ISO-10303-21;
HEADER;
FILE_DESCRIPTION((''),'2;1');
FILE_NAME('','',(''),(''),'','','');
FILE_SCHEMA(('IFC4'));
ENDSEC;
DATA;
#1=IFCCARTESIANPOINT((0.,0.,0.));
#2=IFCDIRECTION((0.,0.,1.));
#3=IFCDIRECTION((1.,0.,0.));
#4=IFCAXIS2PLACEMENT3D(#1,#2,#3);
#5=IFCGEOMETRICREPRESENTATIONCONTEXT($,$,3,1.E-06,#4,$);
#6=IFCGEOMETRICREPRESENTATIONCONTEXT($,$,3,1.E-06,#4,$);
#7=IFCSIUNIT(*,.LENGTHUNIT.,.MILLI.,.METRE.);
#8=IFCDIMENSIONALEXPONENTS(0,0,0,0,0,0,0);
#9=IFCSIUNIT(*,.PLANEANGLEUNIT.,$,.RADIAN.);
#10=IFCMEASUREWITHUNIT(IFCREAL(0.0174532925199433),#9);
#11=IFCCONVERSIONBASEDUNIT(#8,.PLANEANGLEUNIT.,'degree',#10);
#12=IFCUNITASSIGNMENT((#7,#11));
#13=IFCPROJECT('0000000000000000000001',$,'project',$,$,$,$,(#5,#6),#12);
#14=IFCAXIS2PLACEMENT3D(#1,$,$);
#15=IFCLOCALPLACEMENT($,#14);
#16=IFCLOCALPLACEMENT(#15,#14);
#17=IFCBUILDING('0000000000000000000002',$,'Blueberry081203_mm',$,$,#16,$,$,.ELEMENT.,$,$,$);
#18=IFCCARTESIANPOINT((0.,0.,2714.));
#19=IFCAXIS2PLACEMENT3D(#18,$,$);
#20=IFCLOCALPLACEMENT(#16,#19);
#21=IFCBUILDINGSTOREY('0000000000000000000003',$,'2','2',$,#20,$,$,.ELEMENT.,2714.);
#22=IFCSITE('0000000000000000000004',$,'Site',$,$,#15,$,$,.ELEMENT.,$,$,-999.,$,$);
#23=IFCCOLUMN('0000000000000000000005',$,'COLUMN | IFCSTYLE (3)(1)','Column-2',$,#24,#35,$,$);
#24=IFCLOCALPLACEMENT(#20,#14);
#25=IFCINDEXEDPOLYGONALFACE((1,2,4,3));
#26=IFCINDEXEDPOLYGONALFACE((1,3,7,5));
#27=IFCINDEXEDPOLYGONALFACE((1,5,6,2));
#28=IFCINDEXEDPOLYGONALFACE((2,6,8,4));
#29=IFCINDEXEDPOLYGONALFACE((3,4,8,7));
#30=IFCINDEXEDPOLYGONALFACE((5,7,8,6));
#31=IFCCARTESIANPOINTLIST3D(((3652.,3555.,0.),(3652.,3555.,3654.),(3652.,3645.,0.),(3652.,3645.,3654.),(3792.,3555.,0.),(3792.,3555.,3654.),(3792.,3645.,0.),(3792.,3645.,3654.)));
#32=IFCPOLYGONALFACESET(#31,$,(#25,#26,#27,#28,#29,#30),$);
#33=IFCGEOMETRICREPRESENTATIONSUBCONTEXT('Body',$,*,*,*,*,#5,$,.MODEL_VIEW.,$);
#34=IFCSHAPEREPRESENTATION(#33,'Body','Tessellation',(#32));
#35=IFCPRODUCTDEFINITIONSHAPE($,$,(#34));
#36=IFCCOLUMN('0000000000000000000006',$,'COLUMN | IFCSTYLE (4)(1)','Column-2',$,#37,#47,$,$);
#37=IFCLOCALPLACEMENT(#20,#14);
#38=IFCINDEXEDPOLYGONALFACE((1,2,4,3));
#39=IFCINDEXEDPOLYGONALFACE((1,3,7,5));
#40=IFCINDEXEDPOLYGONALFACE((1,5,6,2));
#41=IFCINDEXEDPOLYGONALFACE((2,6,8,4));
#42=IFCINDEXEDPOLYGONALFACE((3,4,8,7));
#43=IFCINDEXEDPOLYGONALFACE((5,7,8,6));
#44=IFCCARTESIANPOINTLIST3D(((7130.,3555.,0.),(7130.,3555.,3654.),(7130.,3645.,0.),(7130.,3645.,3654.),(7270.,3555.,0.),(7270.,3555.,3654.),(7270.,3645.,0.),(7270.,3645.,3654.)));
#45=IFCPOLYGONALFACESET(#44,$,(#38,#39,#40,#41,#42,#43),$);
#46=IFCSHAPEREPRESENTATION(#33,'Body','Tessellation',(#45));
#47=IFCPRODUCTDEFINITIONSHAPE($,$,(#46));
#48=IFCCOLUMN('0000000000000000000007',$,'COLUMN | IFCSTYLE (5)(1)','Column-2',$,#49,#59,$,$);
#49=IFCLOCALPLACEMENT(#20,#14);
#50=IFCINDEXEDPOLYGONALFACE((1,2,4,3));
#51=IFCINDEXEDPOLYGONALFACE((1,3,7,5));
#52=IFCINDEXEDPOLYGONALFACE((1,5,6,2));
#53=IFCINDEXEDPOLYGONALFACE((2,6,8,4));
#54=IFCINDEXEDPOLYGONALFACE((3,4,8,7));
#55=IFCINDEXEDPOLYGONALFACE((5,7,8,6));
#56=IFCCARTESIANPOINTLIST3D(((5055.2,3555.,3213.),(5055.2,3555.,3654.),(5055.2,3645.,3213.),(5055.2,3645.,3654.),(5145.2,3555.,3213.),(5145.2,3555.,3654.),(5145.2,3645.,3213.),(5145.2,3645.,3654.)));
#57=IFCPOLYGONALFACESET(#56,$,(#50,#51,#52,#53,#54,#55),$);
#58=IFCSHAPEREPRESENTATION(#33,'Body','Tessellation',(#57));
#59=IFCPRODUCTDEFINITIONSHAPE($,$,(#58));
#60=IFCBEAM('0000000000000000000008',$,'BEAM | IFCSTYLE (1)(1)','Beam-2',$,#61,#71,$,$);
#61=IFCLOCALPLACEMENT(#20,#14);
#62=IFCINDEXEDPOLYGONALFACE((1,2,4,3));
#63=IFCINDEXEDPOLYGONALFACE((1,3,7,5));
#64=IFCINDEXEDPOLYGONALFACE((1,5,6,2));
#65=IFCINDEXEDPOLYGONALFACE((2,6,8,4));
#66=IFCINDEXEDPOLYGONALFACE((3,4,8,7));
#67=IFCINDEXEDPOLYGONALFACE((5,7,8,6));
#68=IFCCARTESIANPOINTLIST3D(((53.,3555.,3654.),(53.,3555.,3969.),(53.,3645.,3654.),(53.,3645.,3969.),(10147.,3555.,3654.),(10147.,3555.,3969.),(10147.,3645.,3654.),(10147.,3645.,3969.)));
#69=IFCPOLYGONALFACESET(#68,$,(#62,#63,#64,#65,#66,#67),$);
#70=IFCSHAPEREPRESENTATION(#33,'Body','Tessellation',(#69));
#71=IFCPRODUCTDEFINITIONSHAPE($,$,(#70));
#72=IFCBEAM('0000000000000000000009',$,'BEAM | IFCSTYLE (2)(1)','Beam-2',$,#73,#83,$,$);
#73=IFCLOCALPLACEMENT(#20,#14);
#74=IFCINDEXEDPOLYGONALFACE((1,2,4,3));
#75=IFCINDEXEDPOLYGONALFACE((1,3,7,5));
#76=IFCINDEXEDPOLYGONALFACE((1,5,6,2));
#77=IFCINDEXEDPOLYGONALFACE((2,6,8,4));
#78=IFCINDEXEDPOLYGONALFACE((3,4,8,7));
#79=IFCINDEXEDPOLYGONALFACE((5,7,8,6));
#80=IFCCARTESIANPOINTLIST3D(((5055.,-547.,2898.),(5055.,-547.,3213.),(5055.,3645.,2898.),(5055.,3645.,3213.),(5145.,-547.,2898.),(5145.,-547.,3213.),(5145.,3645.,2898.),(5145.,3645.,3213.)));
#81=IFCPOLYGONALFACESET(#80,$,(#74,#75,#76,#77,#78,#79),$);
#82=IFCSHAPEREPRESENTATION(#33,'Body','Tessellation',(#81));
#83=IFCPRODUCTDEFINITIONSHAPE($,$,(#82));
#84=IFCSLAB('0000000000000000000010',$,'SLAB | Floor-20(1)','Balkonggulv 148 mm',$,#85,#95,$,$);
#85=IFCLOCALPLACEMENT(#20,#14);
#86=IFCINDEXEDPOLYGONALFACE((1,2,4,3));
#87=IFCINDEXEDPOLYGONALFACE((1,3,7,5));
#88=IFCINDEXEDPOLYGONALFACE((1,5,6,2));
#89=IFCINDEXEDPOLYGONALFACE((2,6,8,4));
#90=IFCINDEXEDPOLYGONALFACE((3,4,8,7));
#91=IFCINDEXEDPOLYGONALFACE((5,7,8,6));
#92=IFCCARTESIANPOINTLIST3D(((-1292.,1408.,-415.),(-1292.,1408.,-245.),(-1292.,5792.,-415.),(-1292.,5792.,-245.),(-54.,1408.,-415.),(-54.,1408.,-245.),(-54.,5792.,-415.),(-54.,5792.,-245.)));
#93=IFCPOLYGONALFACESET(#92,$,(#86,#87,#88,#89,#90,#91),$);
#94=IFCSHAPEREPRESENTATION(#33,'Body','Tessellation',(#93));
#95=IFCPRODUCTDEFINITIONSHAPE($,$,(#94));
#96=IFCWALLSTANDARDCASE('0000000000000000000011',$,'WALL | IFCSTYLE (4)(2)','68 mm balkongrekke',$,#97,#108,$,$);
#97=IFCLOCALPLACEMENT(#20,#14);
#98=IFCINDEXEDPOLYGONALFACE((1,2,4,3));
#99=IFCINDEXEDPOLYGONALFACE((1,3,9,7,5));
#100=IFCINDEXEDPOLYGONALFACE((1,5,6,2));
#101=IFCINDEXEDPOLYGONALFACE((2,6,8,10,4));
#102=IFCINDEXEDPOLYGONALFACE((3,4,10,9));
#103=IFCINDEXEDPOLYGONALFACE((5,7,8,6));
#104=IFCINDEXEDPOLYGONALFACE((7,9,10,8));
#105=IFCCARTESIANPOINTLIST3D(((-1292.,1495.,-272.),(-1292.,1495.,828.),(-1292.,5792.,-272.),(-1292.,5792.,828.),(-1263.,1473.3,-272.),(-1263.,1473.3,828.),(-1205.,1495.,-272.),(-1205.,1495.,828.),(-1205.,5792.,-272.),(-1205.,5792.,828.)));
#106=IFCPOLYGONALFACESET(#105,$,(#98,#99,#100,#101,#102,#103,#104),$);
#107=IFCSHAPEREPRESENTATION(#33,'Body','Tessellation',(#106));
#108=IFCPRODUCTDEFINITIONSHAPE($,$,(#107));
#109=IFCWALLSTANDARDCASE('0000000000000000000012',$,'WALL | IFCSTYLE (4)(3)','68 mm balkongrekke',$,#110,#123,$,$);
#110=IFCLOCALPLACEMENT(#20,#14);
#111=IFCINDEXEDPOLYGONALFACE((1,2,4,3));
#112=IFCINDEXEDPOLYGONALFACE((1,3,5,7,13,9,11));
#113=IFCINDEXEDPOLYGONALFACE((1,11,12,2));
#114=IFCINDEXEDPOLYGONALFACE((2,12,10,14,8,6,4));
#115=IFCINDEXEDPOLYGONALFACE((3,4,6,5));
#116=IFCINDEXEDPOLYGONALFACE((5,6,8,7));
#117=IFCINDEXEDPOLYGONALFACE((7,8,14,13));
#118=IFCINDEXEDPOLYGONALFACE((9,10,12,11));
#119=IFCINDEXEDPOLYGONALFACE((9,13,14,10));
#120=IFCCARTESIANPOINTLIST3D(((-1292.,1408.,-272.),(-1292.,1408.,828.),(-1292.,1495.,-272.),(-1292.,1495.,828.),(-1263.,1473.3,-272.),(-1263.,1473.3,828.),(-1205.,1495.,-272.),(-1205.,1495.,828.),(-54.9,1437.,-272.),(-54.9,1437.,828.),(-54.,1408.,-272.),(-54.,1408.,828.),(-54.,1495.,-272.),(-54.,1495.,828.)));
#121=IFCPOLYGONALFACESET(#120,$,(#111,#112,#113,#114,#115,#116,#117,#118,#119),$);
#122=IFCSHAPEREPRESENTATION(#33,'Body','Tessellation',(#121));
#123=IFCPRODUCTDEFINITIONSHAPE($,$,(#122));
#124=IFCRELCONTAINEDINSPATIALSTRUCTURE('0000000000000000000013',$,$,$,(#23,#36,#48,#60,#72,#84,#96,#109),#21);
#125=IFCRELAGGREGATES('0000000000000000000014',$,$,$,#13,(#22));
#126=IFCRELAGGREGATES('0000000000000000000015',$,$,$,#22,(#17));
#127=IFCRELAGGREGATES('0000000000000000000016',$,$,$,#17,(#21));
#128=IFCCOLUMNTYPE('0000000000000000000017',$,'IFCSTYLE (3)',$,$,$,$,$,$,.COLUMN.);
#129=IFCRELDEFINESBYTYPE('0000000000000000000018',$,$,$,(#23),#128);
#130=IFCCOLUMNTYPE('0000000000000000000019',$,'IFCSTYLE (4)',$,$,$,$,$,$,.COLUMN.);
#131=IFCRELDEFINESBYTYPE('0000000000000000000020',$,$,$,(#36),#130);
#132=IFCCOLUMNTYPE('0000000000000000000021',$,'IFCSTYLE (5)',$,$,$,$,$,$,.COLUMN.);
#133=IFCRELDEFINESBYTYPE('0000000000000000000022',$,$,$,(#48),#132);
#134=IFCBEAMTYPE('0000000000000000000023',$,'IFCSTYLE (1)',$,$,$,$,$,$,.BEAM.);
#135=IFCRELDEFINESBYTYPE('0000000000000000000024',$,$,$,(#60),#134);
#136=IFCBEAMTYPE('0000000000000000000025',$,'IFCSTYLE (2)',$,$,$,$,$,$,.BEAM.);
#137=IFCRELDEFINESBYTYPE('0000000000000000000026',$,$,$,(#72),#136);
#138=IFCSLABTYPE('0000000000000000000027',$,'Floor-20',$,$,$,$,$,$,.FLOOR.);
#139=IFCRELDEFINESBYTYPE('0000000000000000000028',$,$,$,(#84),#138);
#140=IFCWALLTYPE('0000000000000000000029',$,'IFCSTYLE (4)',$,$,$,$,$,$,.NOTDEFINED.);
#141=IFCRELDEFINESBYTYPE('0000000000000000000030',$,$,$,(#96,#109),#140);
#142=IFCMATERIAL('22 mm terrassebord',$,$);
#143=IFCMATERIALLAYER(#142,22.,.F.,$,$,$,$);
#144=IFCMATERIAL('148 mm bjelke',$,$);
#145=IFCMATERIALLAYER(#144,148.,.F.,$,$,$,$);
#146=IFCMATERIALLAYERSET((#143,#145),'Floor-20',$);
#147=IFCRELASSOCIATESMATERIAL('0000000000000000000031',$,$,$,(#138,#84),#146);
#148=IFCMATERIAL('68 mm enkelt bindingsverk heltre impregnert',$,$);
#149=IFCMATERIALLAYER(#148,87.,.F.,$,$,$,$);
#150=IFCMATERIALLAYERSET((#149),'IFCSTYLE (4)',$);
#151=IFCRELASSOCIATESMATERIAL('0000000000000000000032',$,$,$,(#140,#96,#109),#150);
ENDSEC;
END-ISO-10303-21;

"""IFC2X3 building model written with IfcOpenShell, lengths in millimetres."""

from ifc_helpers import new_model, entity, si_unit, converted_unit, frame, frame_2d, origin, origin_with_axes, place, context, subcontext, project, spatial, polyline, segment, composite_curve, rectangle, outline, extrude, source, transform, mapped, material, layer, layer_set, layer_usage, type_object, element, save


model = new_model("IFC2X3")

# Units and contexts
context_of_model_1 = context(None, 3, precision=1e-06, world=origin_with_axes())
context_of_model_2 = context(None, 3, precision=1e-06, world=origin_with_axes())
body_context = subcontext(context_of_model_1, "Body", None, "MODEL_VIEW")
ifc_project = project(units=[si_unit("LENGTHUNIT", "METRE", prefix="MILLI"), converted_unit("PLANEANGLEUNIT", "degree", entity("IfcReal", 0.0174532925199433), si_unit("PLANEANGLEUNIT", "RADIAN"), dimensions=[0, 0, 0, 0, 0, 0, 0])], contexts=[context_of_model_1, context_of_model_2])

# Site, building, storey
site_placement = place(None, origin())
site = spatial("IfcSite", under=ifc_project, at=site_placement, Name="Site", CompositionType="ELEMENT", RefElevation=-999.0)
building_placement = place(site_placement, origin())
building = spatial("IfcBuilding", under=site, at=building_placement, Name="Blueberry081203_mm", CompositionType="ELEMENT")
storey_placement = place(building_placement, frame((0.0, 0.0, 2714.0)))
storey = spatial("IfcBuildingStorey", under=building, at=storey_placement, Name="2", Description="2", CompositionType="ELEMENT", Elevation=2714.0)

# Columns
column_type_1 = type_object("IfcColumnType", Name="IFCSTYLE (3)", PredefinedType="COLUMN")
shared_shape_1 = source(origin(), body_context, "Body", "SweptSolid", [
    extrude(rectangle(XDim=140.0, YDim=90.0, at=frame_2d((70.0, 45.0), x_axis=(1.0, 0.0))), frame((0.0, 0.0, 0.0), z_axis=(1.0, 0.0, 0.0), x_axis=(0.0, 1.0, 0.0)), (0.0, 0.0, 1.0), 1.0),
])
column_1_placement = place(storey_placement, frame((3652.0, 3555.0, 0.0), z_axis=(0.0, 1.0, 0.0), x_axis=(0.0, 0.0, 1.0)))
element("IfcColumn", 1, at=column_1_placement, inside=storey, type_object=column_type_1, Name="COLUMN | IFCSTYLE (3)(1)", Description="Column-2", context=body_context, shape_type="MappedRepresentation", held_by="IfcProductRepresentation", body=[
    mapped(shared_shape_1, transform((0.0, 0.0, 0.0), x_axis=(1.0, 0.0, 0.0), y_axis=(0.0, 1.0, 0.0), z_axis=(0.0, 0.0, 1.0), scale=3654.000044, scale2=1.0, scale3=1.0, uniform=False)),
])
column_type_2 = type_object("IfcColumnType", Name="IFCSTYLE (4)", PredefinedType="COLUMN")
shared_shape_2 = source(origin(), body_context, "Body", "SweptSolid", [
    extrude(rectangle(XDim=140.0, YDim=90.0, at=frame_2d((70.0, 45.0), x_axis=(1.0, 0.0))), frame((0.0, 0.0, 0.0), z_axis=(1.0, 0.0, 0.0), x_axis=(0.0, 1.0, 0.0)), (0.0, 0.0, 1.0), 1.0),
])
column_2_placement = place(storey_placement, frame((7130.0, 3555.0, 0.0), z_axis=(0.0, 1.0, 0.0), x_axis=(0.0, 0.0, 1.0)))
element("IfcColumn", 2, at=column_2_placement, inside=storey, type_object=column_type_2, Name="COLUMN | IFCSTYLE (4)(1)", Description="Column-2", context=body_context, shape_type="MappedRepresentation", held_by="IfcProductRepresentation", body=[
    mapped(shared_shape_2, transform((0.0, 0.0, 0.0), x_axis=(1.0, 0.0, 0.0), y_axis=(0.0, 1.0, 0.0), z_axis=(0.0, 0.0, 1.0), scale=3654.000044, scale2=1.0, scale3=1.0, uniform=False)),
])
column_type_3 = type_object("IfcColumnType", Name="IFCSTYLE (5)", PredefinedType="COLUMN")
shared_shape_3 = source(origin(), body_context, "Body", "SweptSolid", [
    extrude(rectangle(XDim=90.0, YDim=90.0, at=frame_2d((45.0, 45.0), x_axis=(1.0, 0.0))), frame((0.0, 0.0, 0.0), z_axis=(1.0, 0.0, 0.0), x_axis=(0.0, 1.0, 0.0)), (0.0, 0.0, 1.0), 1.0),
])
column_3_placement = place(storey_placement, frame((5055.2, 3555.0, 3213.0), z_axis=(0.0, 1.0, 0.0), x_axis=(0.0, 0.0, 1.0)))
element("IfcColumn", 3, at=column_3_placement, inside=storey, type_object=column_type_3, Name="COLUMN | IFCSTYLE (5)(1)", Description="Column-2", context=body_context, shape_type="MappedRepresentation", held_by="IfcProductRepresentation", body=[
    mapped(shared_shape_3, transform((0.0, 0.0, 0.0), x_axis=(1.0, 0.0, 0.0), y_axis=(0.0, 1.0, 0.0), z_axis=(0.0, 0.0, 1.0), scale=441.000015, scale2=1.0, scale3=1.0, uniform=False)),
])

# Beams
beam_type_1 = type_object("IfcBeamType", Name="IFCSTYLE (1)", PredefinedType="BEAM")
shared_shape_4 = source(origin(), body_context, "Body", "SweptSolid", [
    extrude(rectangle(XDim=90.0, YDim=315.0, at=frame_2d((45.0, 157.5), x_axis=(1.0, 0.0))), frame((0.0, 0.0, 0.0), z_axis=(1.0, 0.0, 0.0), x_axis=(0.0, 1.0, 0.0)), (0.0, 0.0, 1.0), 1.0),
])
beam_1_placement = place(storey_placement, frame((53.0, 3555.0, 3654.0)))
element("IfcBeam", 4, at=beam_1_placement, inside=storey, type_object=beam_type_1, Name="BEAM | IFCSTYLE (1)(1)", Description="Beam-2", context=body_context, shape_type="MappedRepresentation", held_by="IfcProductRepresentation", body=[
    mapped(shared_shape_4, transform((0.0, 0.0, 0.0), x_axis=(1.0, 0.0, 0.0), y_axis=(0.0, 1.0, 0.0), z_axis=(0.0, 0.0, 1.0), scale=10093.994141, scale2=1.0, scale3=1.0, uniform=False)),
])
beam_type_2 = type_object("IfcBeamType", Name="IFCSTYLE (2)", PredefinedType="BEAM")
shared_shape_5 = source(origin(), body_context, "Body", "SweptSolid", [
    extrude(rectangle(XDim=90.0, YDim=315.0, at=frame_2d((45.0, 157.5), x_axis=(1.0, 0.0))), frame((0.0, 0.0, 0.0), z_axis=(1.0, 0.0, 0.0), x_axis=(0.0, 1.0, 0.0)), (0.0, 0.0, 1.0), 1.0),
])
beam_2_placement = place(storey_placement, frame((5145.0, -547.0, 2898.0), z_axis=(0.0, 0.0, 1.0), x_axis=(0.0, 1.0, 0.0)))
element("IfcBeam", 5, at=beam_2_placement, inside=storey, type_object=beam_type_2, Name="BEAM | IFCSTYLE (2)(1)", Description="Beam-2", context=body_context, shape_type="MappedRepresentation", held_by="IfcProductRepresentation", body=[
    mapped(shared_shape_5, transform((0.0, 0.0, 0.0), x_axis=(1.0, 0.0, 0.0), y_axis=(0.0, 1.0, 0.0), z_axis=(0.0, 0.0, 1.0), scale=4191.995144, scale2=1.0, scale3=1.0, uniform=False)),
])

# Slab
ifc_material_1 = material(Name="22 mm terrassebord")
ifc_layer_1 = layer(ifc_material_1, 22.0, ventilated=False)
ifc_material_2 = material(Name="148 mm bjelke")
ifc_layer_2 = layer(ifc_material_2, 148.0, ventilated=False)
ifc_layer_set_1 = layer_set([ifc_layer_1, ifc_layer_2], Name="Floor-20")
ifc_layer_usage_1 = layer_usage(ifc_layer_set_1, "AXIS3", "POSITIVE", 0.0)
slab_type = type_object("IfcSlabType", Name="Floor-20", PredefinedType="FLOOR", material=ifc_layer_set_1)
slab_placement = place(storey_placement, frame((-1292.0, 1408.0, -245.0)))
element("IfcSlab", 6, at=slab_placement, inside=storey, type_object=slab_type, material=ifc_layer_usage_1, Name="SLAB | Floor-20(1)", Description="Balkonggulv 148 mm", context=body_context, shape_type="SweptSolid", held_by="IfcProductRepresentation", body=[
    extrude(rectangle(XDim=1238.0, YDim=4384.0, at=frame_2d((619.0, 2192.0), x_axis=(1.0, 0.0))), frame((0.0, 0.0, -170.0)), (0.0, 0.0, 1.0), 170.0),
])

# Walls
ifc_material_3 = material(Name="68 mm enkelt bindingsverk heltre impregnert")
ifc_layer_3 = layer(ifc_material_3, 87.0, ventilated=False)
ifc_layer_set_2 = layer_set([ifc_layer_3], Name="IFCSTYLE (4)")
wall_type = type_object("IfcWallType", Name="IFCSTYLE (4)", PredefinedType="NOTDEFINED", material=ifc_layer_set_2)
ifc_layer_usage_2 = layer_usage(ifc_layer_set_2, "AXIS2", "POSITIVE", 0.0)
wall_1_placement = place(storey_placement, frame((-1292.0, 5792.0, -272.0), z_axis=(0.0, 0.0, 1.0), x_axis=(0.0, -1.0, 0.0)))
element("IfcWallStandardCase", 7, at=wall_1_placement, inside=storey, type_object=wall_type, material=ifc_layer_usage_2, Name="WALL | IFCSTYLE (4)(2)", Description="68 mm balkongrekke", context=body_context, shape_type="SweptSolid", held_by="IfcProductRepresentation", body=[
    extrude(outline(composite_curve([segment(polyline([(0.0, 87.0), (0.0, 0.0)]), True, "CONTINUOUS"), segment(polyline([(0.0, 0.0), (4297.0, 0.0)]), True, "CONTINUOUS"), segment(polyline([(4297.0, 0.0), (4318.7, 29.0)]), True, "CONTINUOUS"), segment(polyline([(4318.7, 29.0), (4297.0, 87.0)]), True, "CONTINUOUS"), segment(polyline([(4297.0, 87.0), (0.0, 87.0)]), True, "CONTINUOUS")], self_intersect=False)), origin(), (0.0, 0.0, 1.0), 1100.0),
])
ifc_layer_usage_3 = layer_usage(ifc_layer_set_2, "AXIS2", "POSITIVE", 0.0)
wall_2_placement = place(storey_placement, frame((-1292.0, 1408.0, -272.0)))
element("IfcWallStandardCase", 8, at=wall_2_placement, inside=storey, type_object=wall_type, material=ifc_layer_usage_3, Name="WALL | IFCSTYLE (4)(3)", Description="68 mm balkongrekke", context=body_context, shape_type="SweptSolid", held_by="IfcProductRepresentation", body=[
    extrude(outline(composite_curve([segment(polyline([(0.0, 87.0), (0.0, 0.0)]), True, "CONTINUOUS"), segment(polyline([(0.0, 0.0), (0.0, 0.0)]), True, "CONTINUOUS"), segment(polyline([(0.0, 0.0), (1238.0, 0.0)]), True, "CONTINUOUS"), segment(polyline([(1238.0, 0.0), (1237.1, 29.0)]), True, "CONTINUOUS"), segment(polyline([(1237.1, 29.0), (1238.0, 87.0)]), True, "CONTINUOUS"), segment(polyline([(1238.0, 87.0), (87.0, 87.0)]), True, "CONTINUOUS"), segment(polyline([(87.0, 87.0), (29.0, 65.2)]), True, "CONTINUOUS"), segment(polyline([(29.0, 65.2), (0.0, 87.0)]), True, "CONTINUOUS"), segment(polyline([(0.0, 87.0), (0.0, 87.0)]), True, "CONTINUOUS")], self_intersect=False)), origin(), (0.0, 0.0, 1.0), 1100.0),
])

save(model, "model.ifc")
